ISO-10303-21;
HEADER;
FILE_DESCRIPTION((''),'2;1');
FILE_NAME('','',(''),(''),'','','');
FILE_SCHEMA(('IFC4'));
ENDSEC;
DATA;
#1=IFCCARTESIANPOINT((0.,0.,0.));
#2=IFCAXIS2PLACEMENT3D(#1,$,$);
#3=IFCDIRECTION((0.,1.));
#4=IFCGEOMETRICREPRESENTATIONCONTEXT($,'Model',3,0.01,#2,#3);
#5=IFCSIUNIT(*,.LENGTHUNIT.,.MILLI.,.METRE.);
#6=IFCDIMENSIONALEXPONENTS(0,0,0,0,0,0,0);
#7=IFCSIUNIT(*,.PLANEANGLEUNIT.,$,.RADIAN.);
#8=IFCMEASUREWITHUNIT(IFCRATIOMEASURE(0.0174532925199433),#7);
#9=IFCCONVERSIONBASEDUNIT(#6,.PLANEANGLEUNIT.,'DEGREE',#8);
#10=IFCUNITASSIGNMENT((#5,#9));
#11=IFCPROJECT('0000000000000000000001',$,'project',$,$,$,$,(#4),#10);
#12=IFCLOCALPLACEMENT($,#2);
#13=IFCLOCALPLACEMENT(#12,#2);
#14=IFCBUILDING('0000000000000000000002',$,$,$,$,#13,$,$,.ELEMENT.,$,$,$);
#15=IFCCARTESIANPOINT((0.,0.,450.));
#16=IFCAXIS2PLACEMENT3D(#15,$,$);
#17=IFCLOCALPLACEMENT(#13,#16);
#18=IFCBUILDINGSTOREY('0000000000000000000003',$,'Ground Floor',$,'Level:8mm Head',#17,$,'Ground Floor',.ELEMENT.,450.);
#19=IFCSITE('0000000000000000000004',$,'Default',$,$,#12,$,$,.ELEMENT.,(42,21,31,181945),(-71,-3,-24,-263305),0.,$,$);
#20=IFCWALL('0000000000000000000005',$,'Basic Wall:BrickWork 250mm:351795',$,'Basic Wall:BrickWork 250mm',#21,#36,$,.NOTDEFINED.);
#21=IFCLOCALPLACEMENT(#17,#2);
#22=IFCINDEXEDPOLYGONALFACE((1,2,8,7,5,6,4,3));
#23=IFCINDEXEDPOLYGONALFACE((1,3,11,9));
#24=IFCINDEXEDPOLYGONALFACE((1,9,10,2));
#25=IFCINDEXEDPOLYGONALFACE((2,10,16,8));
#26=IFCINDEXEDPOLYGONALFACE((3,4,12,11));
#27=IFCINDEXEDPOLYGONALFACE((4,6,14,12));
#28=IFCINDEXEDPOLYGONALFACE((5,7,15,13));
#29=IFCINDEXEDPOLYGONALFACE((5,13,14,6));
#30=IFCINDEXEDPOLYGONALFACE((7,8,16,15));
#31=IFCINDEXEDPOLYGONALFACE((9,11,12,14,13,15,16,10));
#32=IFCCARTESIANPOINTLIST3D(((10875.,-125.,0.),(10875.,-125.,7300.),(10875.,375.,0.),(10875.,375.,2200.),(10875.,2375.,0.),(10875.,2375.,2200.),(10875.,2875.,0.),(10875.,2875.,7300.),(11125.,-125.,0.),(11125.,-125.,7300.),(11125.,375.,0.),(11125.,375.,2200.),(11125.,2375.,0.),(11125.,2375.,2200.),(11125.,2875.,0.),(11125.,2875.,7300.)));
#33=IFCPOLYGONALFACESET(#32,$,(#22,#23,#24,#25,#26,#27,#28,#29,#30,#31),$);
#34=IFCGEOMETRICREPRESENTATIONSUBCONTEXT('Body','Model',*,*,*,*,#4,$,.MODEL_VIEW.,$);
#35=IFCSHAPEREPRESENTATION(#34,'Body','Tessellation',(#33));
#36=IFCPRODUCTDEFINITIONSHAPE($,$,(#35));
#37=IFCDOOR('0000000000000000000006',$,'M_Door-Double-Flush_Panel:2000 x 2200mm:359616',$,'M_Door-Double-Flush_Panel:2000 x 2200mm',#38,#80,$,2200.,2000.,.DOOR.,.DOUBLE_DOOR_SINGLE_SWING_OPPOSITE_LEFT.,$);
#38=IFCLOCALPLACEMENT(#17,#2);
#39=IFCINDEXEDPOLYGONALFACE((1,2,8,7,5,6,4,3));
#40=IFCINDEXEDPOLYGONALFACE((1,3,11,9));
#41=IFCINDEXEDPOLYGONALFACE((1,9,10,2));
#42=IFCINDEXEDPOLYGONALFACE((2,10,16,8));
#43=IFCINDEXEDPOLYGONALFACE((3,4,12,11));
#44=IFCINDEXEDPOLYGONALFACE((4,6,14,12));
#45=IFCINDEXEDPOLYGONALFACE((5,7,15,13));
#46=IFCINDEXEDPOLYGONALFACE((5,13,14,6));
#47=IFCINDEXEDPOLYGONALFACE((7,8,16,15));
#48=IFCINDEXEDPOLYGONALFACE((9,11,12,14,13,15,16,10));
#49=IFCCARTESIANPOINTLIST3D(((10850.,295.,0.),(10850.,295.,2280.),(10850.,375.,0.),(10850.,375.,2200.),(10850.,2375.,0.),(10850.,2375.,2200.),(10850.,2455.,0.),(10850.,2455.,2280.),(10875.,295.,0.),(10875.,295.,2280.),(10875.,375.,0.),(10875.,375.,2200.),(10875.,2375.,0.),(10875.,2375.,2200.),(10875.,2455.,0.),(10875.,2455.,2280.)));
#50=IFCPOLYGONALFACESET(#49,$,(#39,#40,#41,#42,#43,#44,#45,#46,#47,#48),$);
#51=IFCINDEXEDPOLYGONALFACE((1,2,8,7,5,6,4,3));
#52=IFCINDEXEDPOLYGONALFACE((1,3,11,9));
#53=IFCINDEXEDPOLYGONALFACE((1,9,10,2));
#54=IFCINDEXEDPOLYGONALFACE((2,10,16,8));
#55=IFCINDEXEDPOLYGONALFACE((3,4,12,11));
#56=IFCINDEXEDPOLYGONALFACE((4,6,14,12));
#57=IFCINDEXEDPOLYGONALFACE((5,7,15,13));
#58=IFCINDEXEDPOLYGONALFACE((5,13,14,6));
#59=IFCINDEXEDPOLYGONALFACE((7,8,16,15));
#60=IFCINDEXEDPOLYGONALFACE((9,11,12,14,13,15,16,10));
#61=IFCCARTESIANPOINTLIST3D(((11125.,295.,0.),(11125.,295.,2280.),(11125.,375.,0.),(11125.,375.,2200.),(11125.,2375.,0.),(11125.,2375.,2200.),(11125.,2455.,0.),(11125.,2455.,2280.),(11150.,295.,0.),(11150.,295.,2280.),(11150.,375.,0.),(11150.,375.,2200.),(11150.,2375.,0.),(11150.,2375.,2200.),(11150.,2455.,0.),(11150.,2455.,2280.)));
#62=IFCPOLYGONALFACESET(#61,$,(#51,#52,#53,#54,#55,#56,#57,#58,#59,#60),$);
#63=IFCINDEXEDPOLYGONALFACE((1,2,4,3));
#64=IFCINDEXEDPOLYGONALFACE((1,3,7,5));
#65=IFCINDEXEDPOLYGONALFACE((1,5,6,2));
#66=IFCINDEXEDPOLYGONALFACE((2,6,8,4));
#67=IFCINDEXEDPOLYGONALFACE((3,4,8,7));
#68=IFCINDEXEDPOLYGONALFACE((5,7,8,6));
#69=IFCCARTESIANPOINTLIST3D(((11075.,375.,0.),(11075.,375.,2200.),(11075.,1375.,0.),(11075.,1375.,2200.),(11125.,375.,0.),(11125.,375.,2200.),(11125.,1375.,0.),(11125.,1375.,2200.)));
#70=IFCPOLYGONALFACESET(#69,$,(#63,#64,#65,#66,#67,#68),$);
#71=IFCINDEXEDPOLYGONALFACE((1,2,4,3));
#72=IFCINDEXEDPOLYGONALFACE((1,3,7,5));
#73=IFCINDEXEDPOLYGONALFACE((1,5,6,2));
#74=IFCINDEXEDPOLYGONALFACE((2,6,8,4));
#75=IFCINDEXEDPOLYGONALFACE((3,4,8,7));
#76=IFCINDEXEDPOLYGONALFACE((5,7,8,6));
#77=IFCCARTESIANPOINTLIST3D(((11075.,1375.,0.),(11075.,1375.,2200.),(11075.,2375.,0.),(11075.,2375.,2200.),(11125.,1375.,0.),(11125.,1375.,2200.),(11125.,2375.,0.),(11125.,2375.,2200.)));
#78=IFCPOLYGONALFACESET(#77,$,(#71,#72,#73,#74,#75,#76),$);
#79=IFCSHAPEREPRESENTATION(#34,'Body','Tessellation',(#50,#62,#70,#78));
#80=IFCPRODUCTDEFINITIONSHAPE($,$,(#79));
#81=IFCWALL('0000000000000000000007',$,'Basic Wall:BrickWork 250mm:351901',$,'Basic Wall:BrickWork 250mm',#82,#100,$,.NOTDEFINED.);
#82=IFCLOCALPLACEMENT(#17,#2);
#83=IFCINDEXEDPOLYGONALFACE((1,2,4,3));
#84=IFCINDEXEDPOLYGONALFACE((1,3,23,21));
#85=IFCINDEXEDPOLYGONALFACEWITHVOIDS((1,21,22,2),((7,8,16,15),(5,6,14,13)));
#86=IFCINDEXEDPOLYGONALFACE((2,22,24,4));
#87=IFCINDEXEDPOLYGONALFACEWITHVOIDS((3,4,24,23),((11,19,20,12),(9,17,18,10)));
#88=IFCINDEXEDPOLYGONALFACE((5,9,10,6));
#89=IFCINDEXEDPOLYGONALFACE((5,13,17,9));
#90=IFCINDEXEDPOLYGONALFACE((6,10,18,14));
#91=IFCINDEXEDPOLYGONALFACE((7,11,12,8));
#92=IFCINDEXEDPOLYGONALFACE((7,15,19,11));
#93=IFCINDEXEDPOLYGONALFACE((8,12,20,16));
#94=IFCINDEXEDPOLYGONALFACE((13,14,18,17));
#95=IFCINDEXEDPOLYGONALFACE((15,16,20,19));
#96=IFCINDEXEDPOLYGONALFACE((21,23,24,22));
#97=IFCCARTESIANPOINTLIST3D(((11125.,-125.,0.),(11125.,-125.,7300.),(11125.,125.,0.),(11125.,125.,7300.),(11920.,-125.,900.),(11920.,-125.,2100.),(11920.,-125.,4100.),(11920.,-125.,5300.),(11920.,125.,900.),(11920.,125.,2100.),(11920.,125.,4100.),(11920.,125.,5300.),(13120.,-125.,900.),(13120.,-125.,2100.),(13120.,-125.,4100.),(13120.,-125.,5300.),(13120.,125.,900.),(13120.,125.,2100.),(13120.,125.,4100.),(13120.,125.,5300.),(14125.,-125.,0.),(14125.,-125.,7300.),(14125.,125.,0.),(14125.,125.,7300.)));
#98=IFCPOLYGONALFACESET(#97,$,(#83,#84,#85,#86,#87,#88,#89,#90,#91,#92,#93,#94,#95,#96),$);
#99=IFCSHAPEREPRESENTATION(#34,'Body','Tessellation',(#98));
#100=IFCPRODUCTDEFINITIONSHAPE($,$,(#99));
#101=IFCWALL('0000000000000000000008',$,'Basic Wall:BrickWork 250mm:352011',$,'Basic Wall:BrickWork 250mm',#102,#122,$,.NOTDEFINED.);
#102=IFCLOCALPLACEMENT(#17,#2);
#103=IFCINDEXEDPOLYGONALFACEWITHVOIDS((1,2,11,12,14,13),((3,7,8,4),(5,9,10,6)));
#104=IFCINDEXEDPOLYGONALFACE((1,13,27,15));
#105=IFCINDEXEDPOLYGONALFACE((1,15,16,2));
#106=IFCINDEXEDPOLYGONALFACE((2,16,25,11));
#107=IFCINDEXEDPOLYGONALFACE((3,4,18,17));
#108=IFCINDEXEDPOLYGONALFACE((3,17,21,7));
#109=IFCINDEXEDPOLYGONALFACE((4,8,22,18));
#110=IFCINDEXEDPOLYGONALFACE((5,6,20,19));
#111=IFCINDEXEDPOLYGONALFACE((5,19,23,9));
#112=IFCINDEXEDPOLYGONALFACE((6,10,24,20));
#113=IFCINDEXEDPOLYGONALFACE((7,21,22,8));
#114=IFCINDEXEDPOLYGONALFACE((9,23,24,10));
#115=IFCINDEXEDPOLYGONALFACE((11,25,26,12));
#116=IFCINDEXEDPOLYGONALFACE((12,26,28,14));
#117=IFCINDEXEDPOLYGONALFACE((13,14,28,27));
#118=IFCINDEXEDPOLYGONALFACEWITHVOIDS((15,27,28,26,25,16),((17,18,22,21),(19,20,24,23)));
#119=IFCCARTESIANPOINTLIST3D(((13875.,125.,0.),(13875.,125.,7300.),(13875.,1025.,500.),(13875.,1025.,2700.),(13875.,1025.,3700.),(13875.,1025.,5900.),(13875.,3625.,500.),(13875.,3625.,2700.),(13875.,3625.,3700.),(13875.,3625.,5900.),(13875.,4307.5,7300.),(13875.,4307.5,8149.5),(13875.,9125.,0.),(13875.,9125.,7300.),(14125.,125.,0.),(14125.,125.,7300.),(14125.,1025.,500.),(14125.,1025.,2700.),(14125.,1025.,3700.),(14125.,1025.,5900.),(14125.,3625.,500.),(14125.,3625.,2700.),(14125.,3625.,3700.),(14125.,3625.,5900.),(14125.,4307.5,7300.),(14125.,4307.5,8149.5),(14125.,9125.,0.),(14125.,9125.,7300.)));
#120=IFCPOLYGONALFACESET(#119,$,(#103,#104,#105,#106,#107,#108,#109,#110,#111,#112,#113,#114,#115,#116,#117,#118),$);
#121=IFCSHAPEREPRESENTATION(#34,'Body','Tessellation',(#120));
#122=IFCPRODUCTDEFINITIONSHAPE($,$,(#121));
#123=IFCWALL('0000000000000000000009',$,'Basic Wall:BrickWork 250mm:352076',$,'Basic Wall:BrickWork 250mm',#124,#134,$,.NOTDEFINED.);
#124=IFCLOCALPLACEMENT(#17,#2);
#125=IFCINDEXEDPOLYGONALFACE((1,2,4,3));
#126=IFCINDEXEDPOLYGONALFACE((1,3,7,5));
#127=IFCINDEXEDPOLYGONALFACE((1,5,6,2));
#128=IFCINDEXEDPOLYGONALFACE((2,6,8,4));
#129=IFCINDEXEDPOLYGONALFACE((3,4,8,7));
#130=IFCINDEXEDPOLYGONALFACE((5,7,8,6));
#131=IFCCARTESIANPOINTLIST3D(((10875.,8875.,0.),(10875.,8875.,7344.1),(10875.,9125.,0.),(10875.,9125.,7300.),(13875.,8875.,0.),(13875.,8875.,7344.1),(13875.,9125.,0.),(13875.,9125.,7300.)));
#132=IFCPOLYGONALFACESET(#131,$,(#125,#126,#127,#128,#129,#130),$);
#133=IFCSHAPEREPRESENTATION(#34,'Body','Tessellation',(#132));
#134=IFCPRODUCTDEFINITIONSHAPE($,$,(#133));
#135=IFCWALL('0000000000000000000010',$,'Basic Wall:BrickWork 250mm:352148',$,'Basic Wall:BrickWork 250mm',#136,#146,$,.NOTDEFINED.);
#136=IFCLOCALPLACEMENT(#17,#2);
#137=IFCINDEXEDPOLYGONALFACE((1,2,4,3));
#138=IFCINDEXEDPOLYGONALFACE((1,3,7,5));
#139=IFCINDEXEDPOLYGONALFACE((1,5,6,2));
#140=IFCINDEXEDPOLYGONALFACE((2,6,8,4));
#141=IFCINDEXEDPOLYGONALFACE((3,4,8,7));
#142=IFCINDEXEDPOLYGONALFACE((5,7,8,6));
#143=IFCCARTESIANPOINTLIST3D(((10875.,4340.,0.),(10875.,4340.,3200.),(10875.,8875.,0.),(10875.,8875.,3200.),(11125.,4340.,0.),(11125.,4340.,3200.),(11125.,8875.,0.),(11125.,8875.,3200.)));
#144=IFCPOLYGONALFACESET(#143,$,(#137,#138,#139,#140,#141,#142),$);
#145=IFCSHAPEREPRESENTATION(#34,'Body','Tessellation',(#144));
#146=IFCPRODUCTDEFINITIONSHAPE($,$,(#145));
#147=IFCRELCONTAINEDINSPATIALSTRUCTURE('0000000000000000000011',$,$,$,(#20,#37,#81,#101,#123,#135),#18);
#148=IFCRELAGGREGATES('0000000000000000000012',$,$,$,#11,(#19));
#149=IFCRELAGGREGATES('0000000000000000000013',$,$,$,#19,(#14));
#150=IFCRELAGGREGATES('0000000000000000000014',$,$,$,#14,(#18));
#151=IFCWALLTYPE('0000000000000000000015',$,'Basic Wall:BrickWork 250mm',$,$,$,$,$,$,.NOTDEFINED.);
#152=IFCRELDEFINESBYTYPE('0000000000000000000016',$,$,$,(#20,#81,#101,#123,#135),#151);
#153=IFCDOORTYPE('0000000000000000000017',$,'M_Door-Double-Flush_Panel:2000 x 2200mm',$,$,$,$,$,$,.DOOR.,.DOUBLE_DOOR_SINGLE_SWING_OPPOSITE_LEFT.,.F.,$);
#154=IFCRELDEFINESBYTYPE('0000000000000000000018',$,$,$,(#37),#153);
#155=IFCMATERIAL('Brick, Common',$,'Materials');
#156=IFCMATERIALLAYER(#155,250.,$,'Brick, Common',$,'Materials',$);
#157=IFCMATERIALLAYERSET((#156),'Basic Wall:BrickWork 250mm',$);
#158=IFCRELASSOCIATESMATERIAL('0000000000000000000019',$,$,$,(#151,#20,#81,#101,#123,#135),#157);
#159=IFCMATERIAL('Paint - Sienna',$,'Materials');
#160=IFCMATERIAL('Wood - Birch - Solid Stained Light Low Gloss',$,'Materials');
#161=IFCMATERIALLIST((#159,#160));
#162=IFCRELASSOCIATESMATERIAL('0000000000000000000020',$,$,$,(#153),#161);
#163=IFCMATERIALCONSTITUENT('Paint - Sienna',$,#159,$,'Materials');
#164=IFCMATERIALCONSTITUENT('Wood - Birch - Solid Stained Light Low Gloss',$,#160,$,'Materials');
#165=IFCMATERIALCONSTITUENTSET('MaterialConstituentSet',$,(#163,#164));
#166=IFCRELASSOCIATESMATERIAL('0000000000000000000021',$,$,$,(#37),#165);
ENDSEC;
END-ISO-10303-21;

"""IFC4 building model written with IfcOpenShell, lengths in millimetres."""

from ifc_helpers import new_model, entity, si_unit, converted_unit, direction, frame, frame_2d, origin, place, context, subcontext, project, spatial, polyline, rectangle, outline, extrude, clip, bounded_halfspace, source, transform, mapped, material, material_list, layer, layer_set, layer_usage, constituent, constituent_set, type_object, type_shapes, element, fill, save


model = new_model("IFC4")

# Units and contexts
model_context = context("Model", 3, precision=0.01, world=origin(), true_north=direction((0.0, 1.0)))
body_context = subcontext(model_context, "Body", "Model", "MODEL_VIEW")
ifc_project = project(units=[si_unit("LENGTHUNIT", "METRE", prefix="MILLI"), converted_unit("PLANEANGLEUNIT", "DEGREE", entity("IfcRatioMeasure", 0.0174532925199433), si_unit("PLANEANGLEUNIT", "RADIAN"), dimensions=[0, 0, 0, 0, 0, 0, 0])], contexts=[model_context])

# Site, building, storey
site_placement = place(None, origin())
site = spatial("IfcSite", under=ifc_project, at=site_placement, Name="Default", CompositionType="ELEMENT", RefLatitude=(42, 21, 31, 181945), RefLongitude=(-71, -3, -24, -263305), RefElevation=0.0)
building_placement = place(site_placement, origin())
building = spatial("IfcBuilding", under=site, at=building_placement, CompositionType="ELEMENT")
storey_placement = place(building_placement, frame((0.0, 0.0, 450.0)))
storey = spatial("IfcBuildingStorey", under=building, at=storey_placement, Name="Ground Floor", ObjectType="Level:8mm Head", LongName="Ground Floor", CompositionType="ELEMENT", Elevation=450.0)

# Wall, opening, door
ifc_material_1 = material(Name="Brick, Common", Category="Materials")
ifc_layer_1 = layer(ifc_material_1, 250.0, Name="Brick, Common", Category="Materials")
ifc_layer_set_1 = layer_set([ifc_layer_1], Name="Basic Wall:BrickWork 250mm")
ifc_layer_usage_1 = layer_usage(ifc_layer_set_1, "AXIS2", "POSITIVE", -125.0)
wall_type_1 = type_object("IfcWallType", Name="Basic Wall:BrickWork 250mm", PredefinedType="NOTDEFINED", material=ifc_layer_set_1)
wall_1_placement = place(storey_placement, frame((11000.0, 2875.0, 0.0), z_axis=(0.0, 0.0, 1.0), x_axis=(0.0, -1.0, 0.0)))
wall_1 = element("IfcWall", 1, at=wall_1_placement, inside=storey, type_object=wall_type_1, material=ifc_layer_usage_1, Name="Basic Wall:BrickWork 250mm:351795", ObjectType="Basic Wall:BrickWork 250mm", PredefinedType="NOTDEFINED", context=body_context, shape_type="SweptSolid", body=[
    extrude(rectangle(XDim=3000.0, YDim=250.0, at=frame_2d((1500.0, 0.0), x_axis=(-1.0, 0.0))), origin(), (0.0, 0.0, 1.0), 7300.0),
])
opening_1_placement = place(wall_1_placement, frame((500.0, -125.0, 0.0)))
opening_1 = element("IfcOpeningElement", 2, at=opening_1_placement, cuts=wall_1, ObjectType="Opening", PredefinedType="OPENING", context=body_context, shape_type="SweptSolid", body=[
    extrude(rectangle(XDim=2200.0, YDim=2000.0, at=frame_2d((1100.0, 1000.0), x_axis=(1.0, 0.0))), frame((0.0, 0.0, 0.0), z_axis=(0.0, 1.0, 0.0), x_axis=(0.0, 0.0, 1.0)), (0.0, 0.0, 1.0), 250.0),
])
ifc_material_2 = material(Name="Paint - Sienna", Category="Materials")
ifc_constituent_1 = constituent(ifc_material_2, Name="Paint - Sienna", Category="Materials")
ifc_material_3 = material(Name="Wood - Birch - Solid Stained Light Low Gloss", Category="Materials")
ifc_constituent_2 = constituent(ifc_material_3, Name="Wood - Birch - Solid Stained Light Low Gloss", Category="Materials")
ifc_constituent_set_1 = constituent_set(constituents=[ifc_constituent_1, ifc_constituent_2], Name="MaterialConstituentSet")
ifc_material_list_1 = material_list([ifc_material_2, ifc_material_3])
door_type_1 = type_object("IfcDoorType", Name="M_Door-Double-Flush_Panel:2000 x 2200mm", OperationType="DOUBLE_DOOR_SINGLE_SWING_OPPOSITE_LEFT", ParameterTakesPrecedence=False, PredefinedType="DOOR", material=ifc_material_list_1)
shared_shape_1 = source(origin(), body_context, "Body", "SweptSolid", [
    extrude(outline(polyline([(-1080.0, 1000.0), (1120.0, 1000.0), (1120.0, 1080.0), (-1160.0, 1080.0), (-1160.0, -1080.0), (1120.0, -1080.0), (1120.0, -1000.0), (-1080.0, -1000.0), (-1080.0, 1000.0)])), frame((1000.0, -25.0, 1120.0), z_axis=(0.0, 1.0, 0.0), x_axis=(0.0, 0.0, -1.0)), (0.0, 0.0, 1.0), 25.0),
    extrude(outline(polyline([(-1080.0, 1000.0), (1120.0, 1000.0), (1120.0, 1080.0), (-1160.0, 1080.0), (-1160.0, -1080.0), (1120.0, -1080.0), (1120.0, -1000.0), (-1080.0, -1000.0), (-1080.0, 1000.0)])), frame((1000.0, 250.0, 1120.0), z_axis=(0.0, 1.0, 0.0), x_axis=(0.0, 0.0, -1.0)), (0.0, 0.0, 1.0), 25.0),
    extrude(rectangle(XDim=50.0, YDim=1000.0, at=frame_2d((0.0, 0.0), x_axis=(1.0, 0.0))), frame((1500.0, 225.0, 0.0), z_axis=(0.0, 0.0, 1.0), x_axis=(0.0, -1.0, 0.0)), (0.0, 0.0, 1.0), 2200.0),
    extrude(rectangle(XDim=50.0, YDim=1000.0, at=frame_2d((0.0, 0.0), x_axis=(1.0, 0.0))), frame((500.0, 225.0, 0.0), z_axis=(0.0, 0.0, 1.0), x_axis=(0.0, -1.0, 0.0)), (0.0, 0.0, 1.0), 2200.0),
])
type_shapes(door_type_1, [shared_shape_1])
door_1_placement = place(opening_1_placement, origin())
door_1 = element("IfcDoor", 3, at=door_1_placement, inside=storey, type_object=door_type_1, material=ifc_constituent_set_1, Name="M_Door-Double-Flush_Panel:2000 x 2200mm:359616", ObjectType="M_Door-Double-Flush_Panel:2000 x 2200mm", OperationType="DOUBLE_DOOR_SINGLE_SWING_OPPOSITE_LEFT", OverallHeight=2200.0, OverallWidth=2000.0, PredefinedType="DOOR", context=body_context, shape_type="MappedRepresentation", body=[
    mapped(shared_shape_1, transform((0.0, 0.0, 0.0), scale=1.0)),
])
fill(opening_1, door_1)

# Walls, openings
ifc_layer_usage_2 = layer_usage(ifc_layer_set_1, "AXIS2", "POSITIVE", -125.0)
wall_2_placement = place(storey_placement, frame((11125.0, 0.0, 0.0)))
wall_2 = element("IfcWall", 4, at=wall_2_placement, inside=storey, type_object=wall_type_1, material=ifc_layer_usage_2, Name="Basic Wall:BrickWork 250mm:351901", ObjectType="Basic Wall:BrickWork 250mm", PredefinedType="NOTDEFINED", context=body_context, shape_type="SweptSolid", body=[
    extrude(rectangle(XDim=3000.0, YDim=250.0, at=frame_2d((1500.0, 0.0), x_axis=(-1.0, 0.0))), origin(), (0.0, 0.0, 1.0), 7300.0),
])
opening_2_placement = place(wall_2_placement, frame((1995.0, 125.0, 900.0)))
element("IfcOpeningElement", 5, at=opening_2_placement, cuts=wall_2, ObjectType="Opening", PredefinedType="OPENING", context=body_context, shape_type="SweptSolid", body=[
    extrude(rectangle(XDim=1200.0, YDim=1200.0, at=frame_2d((600.0, 600.0), x_axis=(-1.0, 0.0))), frame((0.0, 0.0, 0.0), z_axis=(0.0, -1.0, 0.0), x_axis=(0.0, 0.0, 1.0)), (0.0, 0.0, 1.0), 250.0),
])
opening_3_placement = place(wall_2_placement, frame((1995.0, 125.0, 4100.0)))
element("IfcOpeningElement", 6, at=opening_3_placement, cuts=wall_2, ObjectType="Opening", PredefinedType="OPENING", context=body_context, shape_type="SweptSolid", body=[
    extrude(rectangle(XDim=1200.0, YDim=1200.0, at=frame_2d((600.0, 600.0), x_axis=(-1.0, 0.0))), frame((0.0, 0.0, 0.0), z_axis=(0.0, -1.0, 0.0), x_axis=(0.0, 0.0, 1.0)), (0.0, 0.0, 1.0), 250.0),
])
ifc_layer_usage_3 = layer_usage(ifc_layer_set_1, "AXIS2", "POSITIVE", -125.0)
wall_3_placement = place(storey_placement, frame((14000.0, 125.0, 0.0), z_axis=(0.0, 0.0, 1.0), x_axis=(0.0, 1.0, 0.0)))
wall_3 = element("IfcWall", 7, at=wall_3_placement, inside=storey, type_object=wall_type_1, material=ifc_layer_usage_3, Name="Basic Wall:BrickWork 250mm:352011", ObjectType="Basic Wall:BrickWork 250mm", PredefinedType="NOTDEFINED", context=body_context, shape_type="Clipping", body=[
    clip(clip(extrude(rectangle(XDim=9000.0, YDim=250.0, at=frame_2d((4500.0, 0.0), x_axis=(-1.0, 0.0))), origin(), (0.0, 0.0, 1.0), 8149.5), bounded_halfspace(frame((4182.5, -125.0, 8149.5), z_axis=(0.173648, 0.0, 0.984808), x_axis=(0.0, 1.0, 0.0)), False, frame((4182.5, -125.0, 8149.5)), polyline([(0.0, 0.0), (4817.5, 0.0), (4817.5, 250.0), (4567.5, 250.0), (282.5, 250.0), (32.5, 250.0), (0.0, 250.0), (0.0, 0.0)]))), bounded_halfspace(frame((0.0, 125.0, 7300.0), z_axis=(0.0, 0.0, 1.0), x_axis=(0.0, 1.0, 0.0)), False, frame((0.0, 125.0, 7300.0)), polyline([(0.0, 0.0), (0.0, -250.0), (4182.5, -250.0), (4182.5, 0.0), (0.0, 0.0)]))),
])
opening_4_placement = place(wall_3_placement, frame((900.0, 277.4, 500.0)))
element("IfcOpeningElement", 8, at=opening_4_placement, cuts=wall_3, ObjectType="Opening", PredefinedType="OPENING", context=body_context, shape_type="SweptSolid", body=[
    extrude(rectangle(XDim=2200.0, YDim=2600.0, at=frame_2d((0.0, 0.0), x_axis=(1.0, 0.0))), frame((1300.0, -554.8, 1100.0), z_axis=(0.0, 1.0, 0.0), x_axis=(0.0, 0.0, 1.0)), (0.0, 0.0, 1.0), 554.8),
])
opening_5_placement = place(wall_3_placement, frame((900.0, 277.4, 3700.0)))
element("IfcOpeningElement", 9, at=opening_5_placement, cuts=wall_3, ObjectType="Opening", PredefinedType="OPENING", context=body_context, shape_type="SweptSolid", body=[
    extrude(rectangle(XDim=2200.0, YDim=2600.0, at=frame_2d((0.0, 0.0), x_axis=(1.0, 0.0))), frame((1300.0, -554.8, 1100.0), z_axis=(0.0, 1.0, 0.0), x_axis=(0.0, 0.0, 1.0)), (0.0, 0.0, 1.0), 554.8),
])

# Walls
ifc_layer_usage_4 = layer_usage(ifc_layer_set_1, "AXIS2", "POSITIVE", -125.0)
wall_4_placement = place(storey_placement, frame((13875.0, 9000.0, 0.0), z_axis=(0.0, 0.0, 1.0), x_axis=(-1.0, 0.0, 0.0)))
element("IfcWall", 10, at=wall_4_placement, inside=storey, type_object=wall_type_1, material=ifc_layer_usage_4, Name="Basic Wall:BrickWork 250mm:352076", ObjectType="Basic Wall:BrickWork 250mm", PredefinedType="NOTDEFINED", context=body_context, shape_type="Clipping", body=[
    clip(extrude(rectangle(XDim=3000.0, YDim=250.0, at=frame_2d((1500.0, 0.0), x_axis=(-1.0, 0.0))), origin(), (0.0, 0.0, 1.0), 7344.1), bounded_halfspace(frame((0.0, -125.0, 7300.0), z_axis=(0.0, -0.173648, 0.984808), x_axis=(1.0, 0.0, 0.0)), False, frame((0.0, -125.0, 7300.0)), polyline([(0.0, 0.0), (3000.0, 0.0), (3000.0, 250.0), (2750.0, 250.0), (0.0, 250.0), (0.0, 0.0)]))),
])
ifc_layer_usage_5 = layer_usage(ifc_layer_set_1, "AXIS2", "POSITIVE", -125.0)
wall_5_placement = place(storey_placement, frame((11000.0, 8875.0, 0.0), z_axis=(0.0, 0.0, 1.0), x_axis=(0.0, -1.0, 0.0)))
element("IfcWall", 11, at=wall_5_placement, inside=storey, type_object=wall_type_1, material=ifc_layer_usage_5, Name="Basic Wall:BrickWork 250mm:352148", ObjectType="Basic Wall:BrickWork 250mm", PredefinedType="NOTDEFINED", context=body_context, shape_type="SweptSolid", body=[
    extrude(rectangle(XDim=4535.0, YDim=250.0, at=frame_2d((2267.5, 0.0), x_axis=(-1.0, 0.0))), origin(), (0.0, 0.0, 1.0), 3200.0),
])

save(model, "model.ifc")
